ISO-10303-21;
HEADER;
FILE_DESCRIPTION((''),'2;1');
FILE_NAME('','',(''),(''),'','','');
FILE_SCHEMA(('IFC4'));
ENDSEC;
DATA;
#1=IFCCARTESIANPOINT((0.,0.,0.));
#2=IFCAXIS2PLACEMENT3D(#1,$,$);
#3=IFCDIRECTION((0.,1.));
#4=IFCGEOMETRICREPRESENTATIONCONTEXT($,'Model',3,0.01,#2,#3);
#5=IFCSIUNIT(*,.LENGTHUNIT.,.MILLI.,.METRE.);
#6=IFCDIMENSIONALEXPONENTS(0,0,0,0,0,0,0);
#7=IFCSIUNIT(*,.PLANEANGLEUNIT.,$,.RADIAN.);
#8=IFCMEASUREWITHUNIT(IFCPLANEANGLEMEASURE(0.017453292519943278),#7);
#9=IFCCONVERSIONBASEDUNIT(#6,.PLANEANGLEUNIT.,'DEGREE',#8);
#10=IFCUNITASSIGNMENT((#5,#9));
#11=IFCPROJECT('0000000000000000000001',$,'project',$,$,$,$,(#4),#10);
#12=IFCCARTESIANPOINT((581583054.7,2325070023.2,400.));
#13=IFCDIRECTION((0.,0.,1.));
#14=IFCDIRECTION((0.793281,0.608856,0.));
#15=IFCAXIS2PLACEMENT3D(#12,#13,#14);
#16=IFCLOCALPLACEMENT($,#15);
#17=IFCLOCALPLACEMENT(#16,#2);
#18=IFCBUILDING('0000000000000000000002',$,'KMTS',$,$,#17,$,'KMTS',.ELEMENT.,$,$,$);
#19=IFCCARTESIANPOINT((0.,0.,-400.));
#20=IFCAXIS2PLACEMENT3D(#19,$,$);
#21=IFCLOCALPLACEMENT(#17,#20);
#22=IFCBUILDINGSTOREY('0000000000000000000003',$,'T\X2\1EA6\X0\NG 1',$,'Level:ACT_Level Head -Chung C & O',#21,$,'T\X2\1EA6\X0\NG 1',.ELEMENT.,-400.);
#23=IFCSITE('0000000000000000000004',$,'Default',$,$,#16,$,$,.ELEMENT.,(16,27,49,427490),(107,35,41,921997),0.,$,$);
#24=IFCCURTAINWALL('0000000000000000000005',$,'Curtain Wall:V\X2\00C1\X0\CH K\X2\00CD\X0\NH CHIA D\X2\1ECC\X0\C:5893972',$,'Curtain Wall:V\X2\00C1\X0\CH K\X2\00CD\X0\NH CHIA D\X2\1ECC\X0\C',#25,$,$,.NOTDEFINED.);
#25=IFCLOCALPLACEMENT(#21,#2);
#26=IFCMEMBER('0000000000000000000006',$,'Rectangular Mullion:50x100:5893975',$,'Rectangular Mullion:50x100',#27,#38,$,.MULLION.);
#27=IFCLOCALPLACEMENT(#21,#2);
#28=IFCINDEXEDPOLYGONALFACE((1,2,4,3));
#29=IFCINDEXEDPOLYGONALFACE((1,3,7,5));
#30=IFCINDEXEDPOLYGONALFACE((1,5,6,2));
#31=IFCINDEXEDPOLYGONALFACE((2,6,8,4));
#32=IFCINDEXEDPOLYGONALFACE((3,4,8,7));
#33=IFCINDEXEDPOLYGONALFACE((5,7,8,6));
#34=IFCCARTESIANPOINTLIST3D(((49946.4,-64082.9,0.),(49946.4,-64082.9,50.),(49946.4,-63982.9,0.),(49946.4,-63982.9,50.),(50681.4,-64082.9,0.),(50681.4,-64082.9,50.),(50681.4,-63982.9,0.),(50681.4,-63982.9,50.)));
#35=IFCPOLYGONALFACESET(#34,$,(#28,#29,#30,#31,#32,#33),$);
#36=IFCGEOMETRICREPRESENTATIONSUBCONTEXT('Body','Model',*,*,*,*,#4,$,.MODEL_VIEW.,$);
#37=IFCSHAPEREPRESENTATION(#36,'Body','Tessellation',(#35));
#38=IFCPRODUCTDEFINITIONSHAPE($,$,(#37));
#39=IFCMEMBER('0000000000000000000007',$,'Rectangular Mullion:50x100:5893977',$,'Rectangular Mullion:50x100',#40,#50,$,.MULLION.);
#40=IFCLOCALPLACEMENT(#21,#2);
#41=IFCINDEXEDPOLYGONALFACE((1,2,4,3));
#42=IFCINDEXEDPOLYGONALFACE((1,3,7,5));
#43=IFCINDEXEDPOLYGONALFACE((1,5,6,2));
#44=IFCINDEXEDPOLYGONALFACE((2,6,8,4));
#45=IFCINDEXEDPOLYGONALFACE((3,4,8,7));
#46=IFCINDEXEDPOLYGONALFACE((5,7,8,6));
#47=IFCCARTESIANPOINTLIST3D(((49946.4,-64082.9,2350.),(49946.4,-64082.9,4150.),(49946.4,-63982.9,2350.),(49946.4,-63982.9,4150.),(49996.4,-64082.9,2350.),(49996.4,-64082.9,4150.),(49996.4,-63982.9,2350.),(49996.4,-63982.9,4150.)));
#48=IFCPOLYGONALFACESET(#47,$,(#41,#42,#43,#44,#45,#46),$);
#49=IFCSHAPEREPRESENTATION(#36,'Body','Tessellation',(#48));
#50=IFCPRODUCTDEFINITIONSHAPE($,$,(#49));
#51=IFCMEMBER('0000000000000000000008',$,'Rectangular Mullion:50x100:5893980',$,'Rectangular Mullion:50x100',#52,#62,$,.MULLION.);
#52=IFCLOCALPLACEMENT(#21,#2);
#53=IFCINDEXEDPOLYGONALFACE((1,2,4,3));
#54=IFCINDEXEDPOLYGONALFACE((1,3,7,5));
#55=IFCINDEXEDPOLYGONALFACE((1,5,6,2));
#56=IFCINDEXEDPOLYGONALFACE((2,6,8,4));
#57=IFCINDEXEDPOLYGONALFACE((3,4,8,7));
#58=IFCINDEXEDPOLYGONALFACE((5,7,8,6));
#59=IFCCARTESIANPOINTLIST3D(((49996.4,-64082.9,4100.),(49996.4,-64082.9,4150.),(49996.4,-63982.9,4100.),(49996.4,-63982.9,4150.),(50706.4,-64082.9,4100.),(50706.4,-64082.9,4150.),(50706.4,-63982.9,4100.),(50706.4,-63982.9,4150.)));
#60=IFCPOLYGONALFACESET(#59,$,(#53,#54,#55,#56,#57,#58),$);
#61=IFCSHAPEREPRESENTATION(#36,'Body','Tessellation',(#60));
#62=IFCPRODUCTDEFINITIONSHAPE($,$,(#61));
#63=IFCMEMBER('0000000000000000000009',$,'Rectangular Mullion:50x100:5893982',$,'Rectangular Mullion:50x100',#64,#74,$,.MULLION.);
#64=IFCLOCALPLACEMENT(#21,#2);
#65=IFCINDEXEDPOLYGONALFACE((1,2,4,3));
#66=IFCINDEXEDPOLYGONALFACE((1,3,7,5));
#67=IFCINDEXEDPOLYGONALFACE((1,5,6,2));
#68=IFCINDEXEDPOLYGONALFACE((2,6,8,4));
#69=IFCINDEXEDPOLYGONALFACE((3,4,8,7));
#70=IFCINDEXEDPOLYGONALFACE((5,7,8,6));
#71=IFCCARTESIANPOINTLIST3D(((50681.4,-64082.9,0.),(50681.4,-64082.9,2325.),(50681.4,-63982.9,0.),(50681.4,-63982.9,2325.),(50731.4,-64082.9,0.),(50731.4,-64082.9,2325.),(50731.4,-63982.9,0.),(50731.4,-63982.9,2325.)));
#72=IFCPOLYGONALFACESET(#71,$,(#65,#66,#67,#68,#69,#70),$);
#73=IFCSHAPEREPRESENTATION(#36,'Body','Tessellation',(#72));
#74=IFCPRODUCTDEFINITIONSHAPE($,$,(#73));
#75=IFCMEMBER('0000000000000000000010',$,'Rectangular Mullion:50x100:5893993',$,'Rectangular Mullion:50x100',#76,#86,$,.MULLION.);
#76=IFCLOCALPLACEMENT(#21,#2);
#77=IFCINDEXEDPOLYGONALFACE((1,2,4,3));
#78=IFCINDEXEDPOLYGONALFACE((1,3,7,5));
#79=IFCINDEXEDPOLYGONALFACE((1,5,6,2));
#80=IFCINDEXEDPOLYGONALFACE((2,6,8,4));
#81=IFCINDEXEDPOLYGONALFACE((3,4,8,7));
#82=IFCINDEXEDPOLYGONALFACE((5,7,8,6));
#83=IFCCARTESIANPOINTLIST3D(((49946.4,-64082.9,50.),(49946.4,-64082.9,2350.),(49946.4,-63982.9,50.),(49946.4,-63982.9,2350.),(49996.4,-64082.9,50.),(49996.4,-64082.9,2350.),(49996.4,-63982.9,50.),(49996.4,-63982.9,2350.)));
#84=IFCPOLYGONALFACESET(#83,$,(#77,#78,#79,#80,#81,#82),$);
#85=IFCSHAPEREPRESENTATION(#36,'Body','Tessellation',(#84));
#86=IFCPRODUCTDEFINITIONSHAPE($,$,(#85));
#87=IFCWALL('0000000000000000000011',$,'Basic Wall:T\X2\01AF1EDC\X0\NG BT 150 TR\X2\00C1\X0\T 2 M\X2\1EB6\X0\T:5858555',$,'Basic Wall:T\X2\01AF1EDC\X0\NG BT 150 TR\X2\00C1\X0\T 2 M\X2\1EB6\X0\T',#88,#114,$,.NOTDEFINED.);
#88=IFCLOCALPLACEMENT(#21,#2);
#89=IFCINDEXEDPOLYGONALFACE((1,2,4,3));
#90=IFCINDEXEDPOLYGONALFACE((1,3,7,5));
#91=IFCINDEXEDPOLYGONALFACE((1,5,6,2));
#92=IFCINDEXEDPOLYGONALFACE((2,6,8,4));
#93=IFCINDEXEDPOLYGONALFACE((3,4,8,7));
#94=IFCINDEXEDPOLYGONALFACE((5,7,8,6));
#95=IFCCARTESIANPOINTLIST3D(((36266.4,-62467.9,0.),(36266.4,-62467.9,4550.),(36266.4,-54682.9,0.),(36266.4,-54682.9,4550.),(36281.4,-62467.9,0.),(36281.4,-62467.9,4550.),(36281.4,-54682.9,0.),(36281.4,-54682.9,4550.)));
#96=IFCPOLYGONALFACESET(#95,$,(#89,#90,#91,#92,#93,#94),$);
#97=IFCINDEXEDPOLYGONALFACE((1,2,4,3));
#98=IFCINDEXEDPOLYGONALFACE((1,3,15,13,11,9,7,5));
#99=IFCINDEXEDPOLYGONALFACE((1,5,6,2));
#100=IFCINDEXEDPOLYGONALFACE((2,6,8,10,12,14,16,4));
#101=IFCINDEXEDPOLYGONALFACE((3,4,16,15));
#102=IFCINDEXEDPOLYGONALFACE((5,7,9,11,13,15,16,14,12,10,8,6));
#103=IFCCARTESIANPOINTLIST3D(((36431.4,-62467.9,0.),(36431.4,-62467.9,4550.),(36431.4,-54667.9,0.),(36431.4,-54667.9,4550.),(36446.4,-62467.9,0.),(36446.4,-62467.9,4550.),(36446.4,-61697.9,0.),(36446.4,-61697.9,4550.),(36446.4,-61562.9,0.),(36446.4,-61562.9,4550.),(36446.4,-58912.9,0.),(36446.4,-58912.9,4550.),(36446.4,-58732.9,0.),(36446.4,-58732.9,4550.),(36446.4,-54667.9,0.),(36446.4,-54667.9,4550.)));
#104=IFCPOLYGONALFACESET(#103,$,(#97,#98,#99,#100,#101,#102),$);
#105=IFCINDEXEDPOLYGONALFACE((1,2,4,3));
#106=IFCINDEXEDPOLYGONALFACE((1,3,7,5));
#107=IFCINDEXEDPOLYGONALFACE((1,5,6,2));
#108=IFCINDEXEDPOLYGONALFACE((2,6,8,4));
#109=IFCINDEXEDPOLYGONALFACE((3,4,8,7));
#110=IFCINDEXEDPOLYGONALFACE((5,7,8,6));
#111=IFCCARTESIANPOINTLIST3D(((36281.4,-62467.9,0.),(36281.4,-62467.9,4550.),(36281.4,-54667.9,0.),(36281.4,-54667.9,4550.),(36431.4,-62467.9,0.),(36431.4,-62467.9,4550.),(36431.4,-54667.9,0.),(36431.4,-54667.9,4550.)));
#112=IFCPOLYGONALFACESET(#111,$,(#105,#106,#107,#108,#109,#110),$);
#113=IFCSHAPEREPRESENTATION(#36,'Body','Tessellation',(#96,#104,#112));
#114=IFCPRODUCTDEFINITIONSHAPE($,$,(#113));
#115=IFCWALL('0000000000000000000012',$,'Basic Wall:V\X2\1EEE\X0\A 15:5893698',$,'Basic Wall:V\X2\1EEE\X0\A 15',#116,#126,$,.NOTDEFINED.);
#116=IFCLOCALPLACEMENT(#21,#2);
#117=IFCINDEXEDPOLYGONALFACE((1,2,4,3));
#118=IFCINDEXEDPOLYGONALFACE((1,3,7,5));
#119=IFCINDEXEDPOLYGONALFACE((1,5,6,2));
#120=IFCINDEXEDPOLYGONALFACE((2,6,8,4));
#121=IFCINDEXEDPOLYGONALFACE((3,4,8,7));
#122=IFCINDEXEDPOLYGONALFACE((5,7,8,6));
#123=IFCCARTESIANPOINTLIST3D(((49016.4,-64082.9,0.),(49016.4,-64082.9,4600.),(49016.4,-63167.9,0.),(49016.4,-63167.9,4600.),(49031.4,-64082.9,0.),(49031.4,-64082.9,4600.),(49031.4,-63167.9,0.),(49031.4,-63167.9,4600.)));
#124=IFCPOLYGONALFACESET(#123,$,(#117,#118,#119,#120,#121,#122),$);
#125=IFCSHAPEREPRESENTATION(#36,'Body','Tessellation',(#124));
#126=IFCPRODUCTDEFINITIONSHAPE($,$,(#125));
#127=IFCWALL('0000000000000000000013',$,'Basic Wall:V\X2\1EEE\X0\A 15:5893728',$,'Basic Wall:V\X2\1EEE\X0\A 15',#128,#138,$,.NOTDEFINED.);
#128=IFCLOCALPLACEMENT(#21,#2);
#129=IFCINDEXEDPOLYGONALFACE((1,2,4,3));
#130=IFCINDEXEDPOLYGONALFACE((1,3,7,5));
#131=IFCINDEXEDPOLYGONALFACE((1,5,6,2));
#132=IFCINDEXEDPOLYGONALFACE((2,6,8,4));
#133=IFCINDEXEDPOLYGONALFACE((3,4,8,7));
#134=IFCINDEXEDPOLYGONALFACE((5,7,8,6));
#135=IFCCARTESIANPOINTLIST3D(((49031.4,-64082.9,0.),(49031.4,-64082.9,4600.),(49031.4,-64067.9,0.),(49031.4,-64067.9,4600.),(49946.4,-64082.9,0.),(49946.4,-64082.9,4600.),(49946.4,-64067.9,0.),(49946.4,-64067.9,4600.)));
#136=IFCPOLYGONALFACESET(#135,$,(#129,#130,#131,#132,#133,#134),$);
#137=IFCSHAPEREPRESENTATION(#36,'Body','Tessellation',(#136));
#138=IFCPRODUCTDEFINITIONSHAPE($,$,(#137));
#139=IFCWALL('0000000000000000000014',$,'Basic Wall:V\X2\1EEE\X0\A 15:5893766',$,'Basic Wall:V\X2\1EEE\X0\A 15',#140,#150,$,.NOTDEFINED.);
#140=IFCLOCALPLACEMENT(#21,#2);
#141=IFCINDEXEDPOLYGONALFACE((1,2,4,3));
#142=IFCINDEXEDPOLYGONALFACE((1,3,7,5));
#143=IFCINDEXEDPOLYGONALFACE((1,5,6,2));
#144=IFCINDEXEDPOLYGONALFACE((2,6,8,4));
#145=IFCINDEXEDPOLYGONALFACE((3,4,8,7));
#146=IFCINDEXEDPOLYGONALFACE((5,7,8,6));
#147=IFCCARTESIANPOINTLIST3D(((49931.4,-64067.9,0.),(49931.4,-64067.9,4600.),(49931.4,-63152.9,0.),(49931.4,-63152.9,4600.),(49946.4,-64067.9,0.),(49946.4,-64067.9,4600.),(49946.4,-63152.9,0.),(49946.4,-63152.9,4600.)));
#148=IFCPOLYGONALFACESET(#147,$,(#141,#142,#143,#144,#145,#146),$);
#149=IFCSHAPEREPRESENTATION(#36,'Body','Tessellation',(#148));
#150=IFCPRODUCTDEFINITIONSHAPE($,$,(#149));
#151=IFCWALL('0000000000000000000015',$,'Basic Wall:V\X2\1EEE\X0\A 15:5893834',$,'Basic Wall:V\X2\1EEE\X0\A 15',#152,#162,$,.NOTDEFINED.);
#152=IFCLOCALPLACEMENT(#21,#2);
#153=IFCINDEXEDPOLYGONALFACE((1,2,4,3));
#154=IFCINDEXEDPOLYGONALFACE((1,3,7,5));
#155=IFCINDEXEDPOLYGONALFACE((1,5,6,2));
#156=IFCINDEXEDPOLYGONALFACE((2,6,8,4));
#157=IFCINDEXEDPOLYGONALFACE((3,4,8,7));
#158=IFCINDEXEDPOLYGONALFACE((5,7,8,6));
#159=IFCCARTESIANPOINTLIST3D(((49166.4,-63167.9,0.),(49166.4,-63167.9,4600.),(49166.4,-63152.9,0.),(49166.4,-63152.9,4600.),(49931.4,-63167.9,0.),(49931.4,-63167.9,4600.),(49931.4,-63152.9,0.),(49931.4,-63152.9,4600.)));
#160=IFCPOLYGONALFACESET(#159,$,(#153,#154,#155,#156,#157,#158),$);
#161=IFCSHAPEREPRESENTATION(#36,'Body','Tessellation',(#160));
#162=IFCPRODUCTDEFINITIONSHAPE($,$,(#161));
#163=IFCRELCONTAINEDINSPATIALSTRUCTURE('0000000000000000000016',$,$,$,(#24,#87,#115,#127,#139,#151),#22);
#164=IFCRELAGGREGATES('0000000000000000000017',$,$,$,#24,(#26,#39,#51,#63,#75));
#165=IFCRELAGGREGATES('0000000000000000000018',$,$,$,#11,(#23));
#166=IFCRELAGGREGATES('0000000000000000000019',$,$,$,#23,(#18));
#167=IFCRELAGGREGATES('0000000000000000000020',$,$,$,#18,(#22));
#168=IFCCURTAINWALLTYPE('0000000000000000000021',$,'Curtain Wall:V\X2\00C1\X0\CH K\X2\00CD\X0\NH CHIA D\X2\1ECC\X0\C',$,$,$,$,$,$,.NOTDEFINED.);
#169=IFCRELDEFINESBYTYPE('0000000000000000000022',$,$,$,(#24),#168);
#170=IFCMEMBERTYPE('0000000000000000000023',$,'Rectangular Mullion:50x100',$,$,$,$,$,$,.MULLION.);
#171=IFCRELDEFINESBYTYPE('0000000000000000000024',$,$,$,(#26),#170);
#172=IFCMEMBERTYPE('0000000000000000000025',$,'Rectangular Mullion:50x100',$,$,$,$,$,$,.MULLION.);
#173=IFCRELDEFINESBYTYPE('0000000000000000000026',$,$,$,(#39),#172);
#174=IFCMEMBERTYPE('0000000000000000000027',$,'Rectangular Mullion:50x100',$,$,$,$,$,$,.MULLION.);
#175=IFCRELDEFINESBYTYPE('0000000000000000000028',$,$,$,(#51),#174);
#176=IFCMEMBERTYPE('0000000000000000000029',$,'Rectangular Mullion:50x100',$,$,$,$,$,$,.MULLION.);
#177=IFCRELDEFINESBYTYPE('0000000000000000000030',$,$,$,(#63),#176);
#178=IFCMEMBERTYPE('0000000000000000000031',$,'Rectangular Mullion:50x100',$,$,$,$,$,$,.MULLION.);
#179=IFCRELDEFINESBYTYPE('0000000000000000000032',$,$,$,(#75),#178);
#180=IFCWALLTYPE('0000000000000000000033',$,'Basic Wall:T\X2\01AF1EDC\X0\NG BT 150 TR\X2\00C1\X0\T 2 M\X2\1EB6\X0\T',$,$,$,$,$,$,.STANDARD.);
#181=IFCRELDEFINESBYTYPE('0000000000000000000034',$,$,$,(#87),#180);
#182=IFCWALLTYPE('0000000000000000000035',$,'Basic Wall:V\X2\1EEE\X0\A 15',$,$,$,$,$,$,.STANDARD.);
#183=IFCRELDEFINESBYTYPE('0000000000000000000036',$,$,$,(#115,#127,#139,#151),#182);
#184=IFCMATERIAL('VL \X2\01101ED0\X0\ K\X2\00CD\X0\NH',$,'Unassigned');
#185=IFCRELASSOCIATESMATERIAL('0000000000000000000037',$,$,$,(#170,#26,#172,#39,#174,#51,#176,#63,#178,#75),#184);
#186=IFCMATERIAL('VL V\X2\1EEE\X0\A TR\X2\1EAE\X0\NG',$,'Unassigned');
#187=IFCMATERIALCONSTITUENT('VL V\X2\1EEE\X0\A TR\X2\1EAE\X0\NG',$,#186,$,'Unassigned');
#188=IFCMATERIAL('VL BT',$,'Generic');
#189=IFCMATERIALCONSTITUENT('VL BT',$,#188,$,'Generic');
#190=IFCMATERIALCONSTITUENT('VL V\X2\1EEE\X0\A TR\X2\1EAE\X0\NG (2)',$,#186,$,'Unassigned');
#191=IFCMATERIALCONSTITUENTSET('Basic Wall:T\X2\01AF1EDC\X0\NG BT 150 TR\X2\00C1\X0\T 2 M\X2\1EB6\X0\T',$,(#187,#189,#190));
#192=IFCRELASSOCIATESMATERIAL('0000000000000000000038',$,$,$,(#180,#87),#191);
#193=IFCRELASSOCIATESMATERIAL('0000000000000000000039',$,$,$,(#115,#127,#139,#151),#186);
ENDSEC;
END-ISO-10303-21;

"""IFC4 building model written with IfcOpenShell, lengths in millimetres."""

from ifc_helpers import new_model, entity, si_unit, converted_unit, direction, frame, origin, place, context, subcontext, project, spatial, indexed_curve, outline, extrude, source, transform, mapped, material, constituent, constituent_set, type_object, type_shapes, element, aggregate, save


model = new_model("IFC4")

# Units and contexts
model_context = context("Model", 3, precision=0.01, world=origin(), true_north=direction((0.0, 1.0)))
body_context = subcontext(model_context, "Body", "Model", "MODEL_VIEW")
ifc_project = project(units=[si_unit("LENGTHUNIT", "METRE", prefix="MILLI"), converted_unit("PLANEANGLEUNIT", "DEGREE", entity("IfcPlaneAngleMeasure", 0.017453292519943278), si_unit("PLANEANGLEUNIT", "RADIAN"), dimensions=[0, 0, 0, 0, 0, 0, 0])], contexts=[model_context])

# Site, building, storey
site_placement = place(None, frame((581583054.7, 2325070023.2, 400.0), z_axis=(0.0, 0.0, 1.0), x_axis=(0.793281, 0.608856, 0.0)))
site = spatial("IfcSite", under=ifc_project, at=site_placement, Name="Default", CompositionType="ELEMENT", RefLatitude=(16, 27, 49, 427490), RefLongitude=(107, 35, 41, 921997), RefElevation=0.0)
building_placement = place(site_placement, origin())
building = spatial("IfcBuilding", under=site, at=building_placement, Name="KMTS", LongName="KMTS", CompositionType="ELEMENT")
storey_placement = place(building_placement, frame((0.0, 0.0, -400.0)))
storey = spatial("IfcBuildingStorey", under=building, at=storey_placement, Name="TẦNG 1", ObjectType="Level:ACT_Level Head -Chung C & O", LongName="TẦNG 1", CompositionType="ELEMENT", Elevation=-400.0)

# Curtain wall, members
curtain_wall_type = type_object("IfcCurtainWallType", Name="Curtain Wall:VÁCH KÍNH CHIA DỌC", PredefinedType="NOTDEFINED")
curtain_wall_placement = place(storey_placement, frame((0.0, 0.0, 400.0)))
curtain_wall = element("IfcCurtainWall", 1, at=curtain_wall_placement, inside=storey, type_object=curtain_wall_type, Name="Curtain Wall:VÁCH KÍNH CHIA DỌC:5893972", ObjectType="Curtain Wall:VÁCH KÍNH CHIA DỌC", PredefinedType="NOTDEFINED")
ifc_material_1 = material(Name="VL ĐỐ KÍNH", Category="Unassigned")
member_type_1 = type_object("IfcMemberType", Name="Rectangular Mullion:50x100", PredefinedType="MULLION", material=ifc_material_1)
shared_shape_1 = source(origin(), body_context, "Body", "SweptSolid", [
    extrude(outline(indexed_curve([(-25.0, -50.0), (25.0, -50.0), (25.0, 50.0), (-25.0, 50.0), (-25.0, -50.0)], self_intersect=False)), frame((-25.0, 0.0, -735.0), z_axis=(0.0, 0.0, 1.0), x_axis=(-1.0, 0.0, 0.0)), (0.0, 0.0, 1.0), 735.0),
])
type_shapes(member_type_1, [shared_shape_1])
member_1_placement = place(curtain_wall_placement, frame((49946.4, -64032.9, -400.0), z_axis=(-1.0, 0.0, 0.0), x_axis=(0.0, 0.0, -1.0)))
member_1 = element("IfcMember", 2, at=member_1_placement, type_object=member_type_1, material=ifc_material_1, Name="Rectangular Mullion:50x100:5893975", ObjectType="Rectangular Mullion:50x100", PredefinedType="MULLION", context=body_context, shape_type="MappedRepresentation", body=[
    mapped(shared_shape_1, transform((0.0, 0.0, 0.0), scale=1.0)),
])
member_type_2 = type_object("IfcMemberType", Name="Rectangular Mullion:50x100", PredefinedType="MULLION", material=ifc_material_1)
shared_shape_2 = source(origin(), body_context, "Body", "SweptSolid", [
    extrude(outline(indexed_curve([(-25.0, -50.0), (25.0, -50.0), (25.0, 50.0), (-25.0, 50.0), (-25.0, -50.0)], self_intersect=False)), frame((-25.0, 0.0, -1800.0), z_axis=(0.0, 0.0, 1.0), x_axis=(-1.0, 0.0, 0.0)), (0.0, 0.0, 1.0), 1800.0),
])
type_shapes(member_type_2, [shared_shape_2])
member_2_placement = place(curtain_wall_placement, frame((49946.4, -64032.9, 3750.0), z_axis=(0.0, 0.0, 1.0), x_axis=(-1.0, 0.0, 0.0)))
member_2 = element("IfcMember", 3, at=member_2_placement, type_object=member_type_2, material=ifc_material_1, Name="Rectangular Mullion:50x100:5893977", ObjectType="Rectangular Mullion:50x100", PredefinedType="MULLION", context=body_context, shape_type="MappedRepresentation", body=[
    mapped(shared_shape_2, transform((0.0, 0.0, 0.0), scale=1.0)),
])
member_type_3 = type_object("IfcMemberType", Name="Rectangular Mullion:50x100", PredefinedType="MULLION", material=ifc_material_1)
shared_shape_3 = source(origin(), body_context, "Body", "SweptSolid", [
    extrude(outline(indexed_curve([(-25.0, -50.0), (25.0, -50.0), (25.0, 50.0), (-25.0, 50.0), (-25.0, -50.0)], self_intersect=False)), frame((-25.0, 0.0, -710.0), z_axis=(0.0, 0.0, 1.0), x_axis=(-1.0, 0.0, 0.0)), (0.0, 0.0, 1.0), 710.0),
])
type_shapes(member_type_3, [shared_shape_3])
member_3_placement = place(curtain_wall_placement, frame((50706.4, -64032.9, 3750.0), z_axis=(1.0, 0.0, 0.0), x_axis=(0.0, 0.0, 1.0)))
member_3 = element("IfcMember", 4, at=member_3_placement, type_object=member_type_3, material=ifc_material_1, Name="Rectangular Mullion:50x100:5893980", ObjectType="Rectangular Mullion:50x100", PredefinedType="MULLION", context=body_context, shape_type="MappedRepresentation", body=[
    mapped(shared_shape_3, transform((0.0, 0.0, 0.0), scale=1.0)),
])
member_type_4 = type_object("IfcMemberType", Name="Rectangular Mullion:50x100", PredefinedType="MULLION", material=ifc_material_1)
shared_shape_4 = source(origin(), body_context, "Body", "SweptSolid", [
    extrude(outline(indexed_curve([(-25.0, -50.0), (25.0, -50.0), (25.0, 50.0), (-25.0, 50.0), (-25.0, -50.0)], self_intersect=False)), frame((0.0, 0.0, -2325.0), z_axis=(0.0, 0.0, 1.0), x_axis=(-1.0, 0.0, 0.0)), (0.0, 0.0, 1.0), 2325.0),
])
type_shapes(member_type_4, [shared_shape_4])
member_4_placement = place(curtain_wall_placement, frame((50706.4, -64032.9, -400.0), z_axis=(0.0, 0.0, -1.0), x_axis=(1.0, 0.0, 0.0)))
member_4 = element("IfcMember", 5, at=member_4_placement, type_object=member_type_4, material=ifc_material_1, Name="Rectangular Mullion:50x100:5893982", ObjectType="Rectangular Mullion:50x100", PredefinedType="MULLION", context=body_context, shape_type="MappedRepresentation", body=[
    mapped(shared_shape_4, transform((0.0, 0.0, 0.0), scale=1.0)),
])
member_type_5 = type_object("IfcMemberType", Name="Rectangular Mullion:50x100", PredefinedType="MULLION", material=ifc_material_1)
shared_shape_5 = source(origin(), body_context, "Body", "SweptSolid", [
    extrude(outline(indexed_curve([(-25.0, -50.0), (25.0, -50.0), (25.0, 50.0), (-25.0, 50.0), (-25.0, -50.0)], self_intersect=False)), frame((-25.0, 0.0, -2300.0), z_axis=(0.0, 0.0, 1.0), x_axis=(-1.0, 0.0, 0.0)), (0.0, 0.0, 1.0), 2300.0),
])
type_shapes(member_type_5, [shared_shape_5])
member_5_placement = place(curtain_wall_placement, frame((49946.4, -64032.9, 1950.0), z_axis=(0.0, 0.0, 1.0), x_axis=(-1.0, 0.0, 0.0)))
member_5 = element("IfcMember", 6, at=member_5_placement, type_object=member_type_5, material=ifc_material_1, Name="Rectangular Mullion:50x100:5893993", ObjectType="Rectangular Mullion:50x100", PredefinedType="MULLION", context=body_context, shape_type="MappedRepresentation", body=[
    mapped(shared_shape_5, transform((0.0, 0.0, 0.0), scale=1.0)),
])
aggregate(curtain_wall, [member_1, member_2, member_3, member_4, member_5])

# Wall
ifc_material_2 = material(Name="VL VỮA TRẮNG", Category="Unassigned")
ifc_constituent_1 = constituent(ifc_material_2, Name="VL VỮA TRẮNG", Category="Unassigned")
ifc_material_3 = material(Name="VL BT", Category="Generic")
ifc_constituent_2 = constituent(ifc_material_3, Name="VL BT", Category="Generic")
ifc_constituent_3 = constituent(ifc_material_2, Name="VL VỮA TRẮNG (2)", Category="Unassigned")
ifc_constituent_set_1 = constituent_set(constituents=[ifc_constituent_1, ifc_constituent_2, ifc_constituent_3], Name="Basic Wall:TƯỜNG BT 150 TRÁT 2 MẶT")
wall_type_1 = type_object("IfcWallType", Name="Basic Wall:TƯỜNG BT 150 TRÁT 2 MẶT", PredefinedType="STANDARD", material=ifc_constituent_set_1)
wall_1_placement = place(storey_placement, frame((36356.4, -54667.9, 0.0), z_axis=(0.0, 0.0, 1.0), x_axis=(0.0, -1.0, 0.0)))
element("IfcWall", 7, at=wall_1_placement, inside=storey, type_object=wall_type_1, material=ifc_constituent_set_1, Name="Basic Wall:TƯỜNG BT 150 TRÁT 2 MẶT:5858555", ObjectType="Basic Wall:TƯỜNG BT 150 TRÁT 2 MẶT", PredefinedType="NOTDEFINED", context=body_context, shape_type="SweptSolid", body=[
    extrude(outline(indexed_curve([(-7.5, -3892.5), (7.5, -3892.5), (7.5, 3892.5), (-7.5, 3892.5), (-7.5, -3892.5)], self_intersect=False)), frame((3907.5, -82.5, 0.0), z_axis=(0.0, 0.0, 1.0), x_axis=(0.0, 1.0, 0.0)), (0.0, 0.0, 1.0), 4550.0),
    extrude(outline(indexed_curve([(-2300.6, -3.7), (-2165.6, -3.7), (484.4, -3.7), (664.4, -3.8), (4729.4, -3.8), (4729.4, 11.2), (-3070.6, 11.3), (-3070.6, -3.7), (-2300.6, -3.7)], self_intersect=False)), frame((4729.4, 86.3, 0.0), z_axis=(0.0, 0.0, 1.0), x_axis=(-1.0, 0.0, 0.0)), (0.0, 0.0, 1.0), 4550.0),
    extrude(outline(indexed_curve([(-3900.0, -75.0), (3900.0, -75.0), (3900.0, 75.0), (-3900.0, 75.0), (-3900.0, -75.0)], self_intersect=False)), frame((3900.0, 0.0, 0.0)), (0.0, 0.0, 1.0), 4550.0),
])

# Walls
wall_type_2 = type_object("IfcWallType", Name="Basic Wall:VỮA 15", PredefinedType="STANDARD")
wall_2_placement = place(storey_placement, frame((49023.9, -63167.9, 0.0), z_axis=(0.0, 0.0, 1.0), x_axis=(0.0, -1.0, 0.0)))
element("IfcWall", 8, at=wall_2_placement, inside=storey, type_object=wall_type_2, material=ifc_material_2, Name="Basic Wall:VỮA 15:5893698", ObjectType="Basic Wall:VỮA 15", PredefinedType="NOTDEFINED", context=body_context, shape_type="SweptSolid", body=[
    extrude(outline(indexed_curve([(915.0, 7.5), (0.0, 7.5), (0.0, -7.5), (915.0, -7.5), (915.0, 7.5)], self_intersect=False)), origin(), (0.0, 0.0, 1.0), 4600.0),
])
wall_3_placement = place(storey_placement, frame((49031.4, -64075.4, 0.0)))
element("IfcWall", 9, at=wall_3_placement, inside=storey, type_object=wall_type_2, material=ifc_material_2, Name="Basic Wall:VỮA 15:5893728", ObjectType="Basic Wall:VỮA 15", PredefinedType="NOTDEFINED", context=body_context, shape_type="SweptSolid", body=[
    extrude(outline(indexed_curve([(915.0, 7.5), (0.0, 7.5), (0.0, -7.5), (915.0, -7.5), (915.0, 7.5)], self_intersect=False)), origin(), (0.0, 0.0, 1.0), 4600.0),
])
wall_4_placement = place(storey_placement, frame((49938.9, -64067.9, 0.0), z_axis=(0.0, 0.0, 1.0), x_axis=(0.0, 1.0, 0.0)))
element("IfcWall", 10, at=wall_4_placement, inside=storey, type_object=wall_type_2, material=ifc_material_2, Name="Basic Wall:VỮA 15:5893766", ObjectType="Basic Wall:VỮA 15", PredefinedType="NOTDEFINED", context=body_context, shape_type="SweptSolid", body=[
    extrude(outline(indexed_curve([(915.0, 7.5), (0.0, 7.5), (0.0, -7.5), (915.0, -7.5), (915.0, 7.5)], self_intersect=False)), origin(), (0.0, 0.0, 1.0), 4600.0),
])
wall_5_placement = place(storey_placement, frame((49931.4, -63160.4, 0.0), z_axis=(0.0, 0.0, 1.0), x_axis=(-1.0, 0.0, 0.0)))
element("IfcWall", 11, at=wall_5_placement, inside=storey, type_object=wall_type_2, material=ifc_material_2, Name="Basic Wall:VỮA 15:5893834", ObjectType="Basic Wall:VỮA 15", PredefinedType="NOTDEFINED", context=body_context, shape_type="SweptSolid", body=[
    extrude(outline(indexed_curve([(765.0, 7.5), (0.0, 7.5), (0.0, -7.5), (765.0, -7.5), (765.0, 7.5)], self_intersect=False)), origin(), (0.0, 0.0, 1.0), 4600.0),
])

save(model, "model.ifc")
